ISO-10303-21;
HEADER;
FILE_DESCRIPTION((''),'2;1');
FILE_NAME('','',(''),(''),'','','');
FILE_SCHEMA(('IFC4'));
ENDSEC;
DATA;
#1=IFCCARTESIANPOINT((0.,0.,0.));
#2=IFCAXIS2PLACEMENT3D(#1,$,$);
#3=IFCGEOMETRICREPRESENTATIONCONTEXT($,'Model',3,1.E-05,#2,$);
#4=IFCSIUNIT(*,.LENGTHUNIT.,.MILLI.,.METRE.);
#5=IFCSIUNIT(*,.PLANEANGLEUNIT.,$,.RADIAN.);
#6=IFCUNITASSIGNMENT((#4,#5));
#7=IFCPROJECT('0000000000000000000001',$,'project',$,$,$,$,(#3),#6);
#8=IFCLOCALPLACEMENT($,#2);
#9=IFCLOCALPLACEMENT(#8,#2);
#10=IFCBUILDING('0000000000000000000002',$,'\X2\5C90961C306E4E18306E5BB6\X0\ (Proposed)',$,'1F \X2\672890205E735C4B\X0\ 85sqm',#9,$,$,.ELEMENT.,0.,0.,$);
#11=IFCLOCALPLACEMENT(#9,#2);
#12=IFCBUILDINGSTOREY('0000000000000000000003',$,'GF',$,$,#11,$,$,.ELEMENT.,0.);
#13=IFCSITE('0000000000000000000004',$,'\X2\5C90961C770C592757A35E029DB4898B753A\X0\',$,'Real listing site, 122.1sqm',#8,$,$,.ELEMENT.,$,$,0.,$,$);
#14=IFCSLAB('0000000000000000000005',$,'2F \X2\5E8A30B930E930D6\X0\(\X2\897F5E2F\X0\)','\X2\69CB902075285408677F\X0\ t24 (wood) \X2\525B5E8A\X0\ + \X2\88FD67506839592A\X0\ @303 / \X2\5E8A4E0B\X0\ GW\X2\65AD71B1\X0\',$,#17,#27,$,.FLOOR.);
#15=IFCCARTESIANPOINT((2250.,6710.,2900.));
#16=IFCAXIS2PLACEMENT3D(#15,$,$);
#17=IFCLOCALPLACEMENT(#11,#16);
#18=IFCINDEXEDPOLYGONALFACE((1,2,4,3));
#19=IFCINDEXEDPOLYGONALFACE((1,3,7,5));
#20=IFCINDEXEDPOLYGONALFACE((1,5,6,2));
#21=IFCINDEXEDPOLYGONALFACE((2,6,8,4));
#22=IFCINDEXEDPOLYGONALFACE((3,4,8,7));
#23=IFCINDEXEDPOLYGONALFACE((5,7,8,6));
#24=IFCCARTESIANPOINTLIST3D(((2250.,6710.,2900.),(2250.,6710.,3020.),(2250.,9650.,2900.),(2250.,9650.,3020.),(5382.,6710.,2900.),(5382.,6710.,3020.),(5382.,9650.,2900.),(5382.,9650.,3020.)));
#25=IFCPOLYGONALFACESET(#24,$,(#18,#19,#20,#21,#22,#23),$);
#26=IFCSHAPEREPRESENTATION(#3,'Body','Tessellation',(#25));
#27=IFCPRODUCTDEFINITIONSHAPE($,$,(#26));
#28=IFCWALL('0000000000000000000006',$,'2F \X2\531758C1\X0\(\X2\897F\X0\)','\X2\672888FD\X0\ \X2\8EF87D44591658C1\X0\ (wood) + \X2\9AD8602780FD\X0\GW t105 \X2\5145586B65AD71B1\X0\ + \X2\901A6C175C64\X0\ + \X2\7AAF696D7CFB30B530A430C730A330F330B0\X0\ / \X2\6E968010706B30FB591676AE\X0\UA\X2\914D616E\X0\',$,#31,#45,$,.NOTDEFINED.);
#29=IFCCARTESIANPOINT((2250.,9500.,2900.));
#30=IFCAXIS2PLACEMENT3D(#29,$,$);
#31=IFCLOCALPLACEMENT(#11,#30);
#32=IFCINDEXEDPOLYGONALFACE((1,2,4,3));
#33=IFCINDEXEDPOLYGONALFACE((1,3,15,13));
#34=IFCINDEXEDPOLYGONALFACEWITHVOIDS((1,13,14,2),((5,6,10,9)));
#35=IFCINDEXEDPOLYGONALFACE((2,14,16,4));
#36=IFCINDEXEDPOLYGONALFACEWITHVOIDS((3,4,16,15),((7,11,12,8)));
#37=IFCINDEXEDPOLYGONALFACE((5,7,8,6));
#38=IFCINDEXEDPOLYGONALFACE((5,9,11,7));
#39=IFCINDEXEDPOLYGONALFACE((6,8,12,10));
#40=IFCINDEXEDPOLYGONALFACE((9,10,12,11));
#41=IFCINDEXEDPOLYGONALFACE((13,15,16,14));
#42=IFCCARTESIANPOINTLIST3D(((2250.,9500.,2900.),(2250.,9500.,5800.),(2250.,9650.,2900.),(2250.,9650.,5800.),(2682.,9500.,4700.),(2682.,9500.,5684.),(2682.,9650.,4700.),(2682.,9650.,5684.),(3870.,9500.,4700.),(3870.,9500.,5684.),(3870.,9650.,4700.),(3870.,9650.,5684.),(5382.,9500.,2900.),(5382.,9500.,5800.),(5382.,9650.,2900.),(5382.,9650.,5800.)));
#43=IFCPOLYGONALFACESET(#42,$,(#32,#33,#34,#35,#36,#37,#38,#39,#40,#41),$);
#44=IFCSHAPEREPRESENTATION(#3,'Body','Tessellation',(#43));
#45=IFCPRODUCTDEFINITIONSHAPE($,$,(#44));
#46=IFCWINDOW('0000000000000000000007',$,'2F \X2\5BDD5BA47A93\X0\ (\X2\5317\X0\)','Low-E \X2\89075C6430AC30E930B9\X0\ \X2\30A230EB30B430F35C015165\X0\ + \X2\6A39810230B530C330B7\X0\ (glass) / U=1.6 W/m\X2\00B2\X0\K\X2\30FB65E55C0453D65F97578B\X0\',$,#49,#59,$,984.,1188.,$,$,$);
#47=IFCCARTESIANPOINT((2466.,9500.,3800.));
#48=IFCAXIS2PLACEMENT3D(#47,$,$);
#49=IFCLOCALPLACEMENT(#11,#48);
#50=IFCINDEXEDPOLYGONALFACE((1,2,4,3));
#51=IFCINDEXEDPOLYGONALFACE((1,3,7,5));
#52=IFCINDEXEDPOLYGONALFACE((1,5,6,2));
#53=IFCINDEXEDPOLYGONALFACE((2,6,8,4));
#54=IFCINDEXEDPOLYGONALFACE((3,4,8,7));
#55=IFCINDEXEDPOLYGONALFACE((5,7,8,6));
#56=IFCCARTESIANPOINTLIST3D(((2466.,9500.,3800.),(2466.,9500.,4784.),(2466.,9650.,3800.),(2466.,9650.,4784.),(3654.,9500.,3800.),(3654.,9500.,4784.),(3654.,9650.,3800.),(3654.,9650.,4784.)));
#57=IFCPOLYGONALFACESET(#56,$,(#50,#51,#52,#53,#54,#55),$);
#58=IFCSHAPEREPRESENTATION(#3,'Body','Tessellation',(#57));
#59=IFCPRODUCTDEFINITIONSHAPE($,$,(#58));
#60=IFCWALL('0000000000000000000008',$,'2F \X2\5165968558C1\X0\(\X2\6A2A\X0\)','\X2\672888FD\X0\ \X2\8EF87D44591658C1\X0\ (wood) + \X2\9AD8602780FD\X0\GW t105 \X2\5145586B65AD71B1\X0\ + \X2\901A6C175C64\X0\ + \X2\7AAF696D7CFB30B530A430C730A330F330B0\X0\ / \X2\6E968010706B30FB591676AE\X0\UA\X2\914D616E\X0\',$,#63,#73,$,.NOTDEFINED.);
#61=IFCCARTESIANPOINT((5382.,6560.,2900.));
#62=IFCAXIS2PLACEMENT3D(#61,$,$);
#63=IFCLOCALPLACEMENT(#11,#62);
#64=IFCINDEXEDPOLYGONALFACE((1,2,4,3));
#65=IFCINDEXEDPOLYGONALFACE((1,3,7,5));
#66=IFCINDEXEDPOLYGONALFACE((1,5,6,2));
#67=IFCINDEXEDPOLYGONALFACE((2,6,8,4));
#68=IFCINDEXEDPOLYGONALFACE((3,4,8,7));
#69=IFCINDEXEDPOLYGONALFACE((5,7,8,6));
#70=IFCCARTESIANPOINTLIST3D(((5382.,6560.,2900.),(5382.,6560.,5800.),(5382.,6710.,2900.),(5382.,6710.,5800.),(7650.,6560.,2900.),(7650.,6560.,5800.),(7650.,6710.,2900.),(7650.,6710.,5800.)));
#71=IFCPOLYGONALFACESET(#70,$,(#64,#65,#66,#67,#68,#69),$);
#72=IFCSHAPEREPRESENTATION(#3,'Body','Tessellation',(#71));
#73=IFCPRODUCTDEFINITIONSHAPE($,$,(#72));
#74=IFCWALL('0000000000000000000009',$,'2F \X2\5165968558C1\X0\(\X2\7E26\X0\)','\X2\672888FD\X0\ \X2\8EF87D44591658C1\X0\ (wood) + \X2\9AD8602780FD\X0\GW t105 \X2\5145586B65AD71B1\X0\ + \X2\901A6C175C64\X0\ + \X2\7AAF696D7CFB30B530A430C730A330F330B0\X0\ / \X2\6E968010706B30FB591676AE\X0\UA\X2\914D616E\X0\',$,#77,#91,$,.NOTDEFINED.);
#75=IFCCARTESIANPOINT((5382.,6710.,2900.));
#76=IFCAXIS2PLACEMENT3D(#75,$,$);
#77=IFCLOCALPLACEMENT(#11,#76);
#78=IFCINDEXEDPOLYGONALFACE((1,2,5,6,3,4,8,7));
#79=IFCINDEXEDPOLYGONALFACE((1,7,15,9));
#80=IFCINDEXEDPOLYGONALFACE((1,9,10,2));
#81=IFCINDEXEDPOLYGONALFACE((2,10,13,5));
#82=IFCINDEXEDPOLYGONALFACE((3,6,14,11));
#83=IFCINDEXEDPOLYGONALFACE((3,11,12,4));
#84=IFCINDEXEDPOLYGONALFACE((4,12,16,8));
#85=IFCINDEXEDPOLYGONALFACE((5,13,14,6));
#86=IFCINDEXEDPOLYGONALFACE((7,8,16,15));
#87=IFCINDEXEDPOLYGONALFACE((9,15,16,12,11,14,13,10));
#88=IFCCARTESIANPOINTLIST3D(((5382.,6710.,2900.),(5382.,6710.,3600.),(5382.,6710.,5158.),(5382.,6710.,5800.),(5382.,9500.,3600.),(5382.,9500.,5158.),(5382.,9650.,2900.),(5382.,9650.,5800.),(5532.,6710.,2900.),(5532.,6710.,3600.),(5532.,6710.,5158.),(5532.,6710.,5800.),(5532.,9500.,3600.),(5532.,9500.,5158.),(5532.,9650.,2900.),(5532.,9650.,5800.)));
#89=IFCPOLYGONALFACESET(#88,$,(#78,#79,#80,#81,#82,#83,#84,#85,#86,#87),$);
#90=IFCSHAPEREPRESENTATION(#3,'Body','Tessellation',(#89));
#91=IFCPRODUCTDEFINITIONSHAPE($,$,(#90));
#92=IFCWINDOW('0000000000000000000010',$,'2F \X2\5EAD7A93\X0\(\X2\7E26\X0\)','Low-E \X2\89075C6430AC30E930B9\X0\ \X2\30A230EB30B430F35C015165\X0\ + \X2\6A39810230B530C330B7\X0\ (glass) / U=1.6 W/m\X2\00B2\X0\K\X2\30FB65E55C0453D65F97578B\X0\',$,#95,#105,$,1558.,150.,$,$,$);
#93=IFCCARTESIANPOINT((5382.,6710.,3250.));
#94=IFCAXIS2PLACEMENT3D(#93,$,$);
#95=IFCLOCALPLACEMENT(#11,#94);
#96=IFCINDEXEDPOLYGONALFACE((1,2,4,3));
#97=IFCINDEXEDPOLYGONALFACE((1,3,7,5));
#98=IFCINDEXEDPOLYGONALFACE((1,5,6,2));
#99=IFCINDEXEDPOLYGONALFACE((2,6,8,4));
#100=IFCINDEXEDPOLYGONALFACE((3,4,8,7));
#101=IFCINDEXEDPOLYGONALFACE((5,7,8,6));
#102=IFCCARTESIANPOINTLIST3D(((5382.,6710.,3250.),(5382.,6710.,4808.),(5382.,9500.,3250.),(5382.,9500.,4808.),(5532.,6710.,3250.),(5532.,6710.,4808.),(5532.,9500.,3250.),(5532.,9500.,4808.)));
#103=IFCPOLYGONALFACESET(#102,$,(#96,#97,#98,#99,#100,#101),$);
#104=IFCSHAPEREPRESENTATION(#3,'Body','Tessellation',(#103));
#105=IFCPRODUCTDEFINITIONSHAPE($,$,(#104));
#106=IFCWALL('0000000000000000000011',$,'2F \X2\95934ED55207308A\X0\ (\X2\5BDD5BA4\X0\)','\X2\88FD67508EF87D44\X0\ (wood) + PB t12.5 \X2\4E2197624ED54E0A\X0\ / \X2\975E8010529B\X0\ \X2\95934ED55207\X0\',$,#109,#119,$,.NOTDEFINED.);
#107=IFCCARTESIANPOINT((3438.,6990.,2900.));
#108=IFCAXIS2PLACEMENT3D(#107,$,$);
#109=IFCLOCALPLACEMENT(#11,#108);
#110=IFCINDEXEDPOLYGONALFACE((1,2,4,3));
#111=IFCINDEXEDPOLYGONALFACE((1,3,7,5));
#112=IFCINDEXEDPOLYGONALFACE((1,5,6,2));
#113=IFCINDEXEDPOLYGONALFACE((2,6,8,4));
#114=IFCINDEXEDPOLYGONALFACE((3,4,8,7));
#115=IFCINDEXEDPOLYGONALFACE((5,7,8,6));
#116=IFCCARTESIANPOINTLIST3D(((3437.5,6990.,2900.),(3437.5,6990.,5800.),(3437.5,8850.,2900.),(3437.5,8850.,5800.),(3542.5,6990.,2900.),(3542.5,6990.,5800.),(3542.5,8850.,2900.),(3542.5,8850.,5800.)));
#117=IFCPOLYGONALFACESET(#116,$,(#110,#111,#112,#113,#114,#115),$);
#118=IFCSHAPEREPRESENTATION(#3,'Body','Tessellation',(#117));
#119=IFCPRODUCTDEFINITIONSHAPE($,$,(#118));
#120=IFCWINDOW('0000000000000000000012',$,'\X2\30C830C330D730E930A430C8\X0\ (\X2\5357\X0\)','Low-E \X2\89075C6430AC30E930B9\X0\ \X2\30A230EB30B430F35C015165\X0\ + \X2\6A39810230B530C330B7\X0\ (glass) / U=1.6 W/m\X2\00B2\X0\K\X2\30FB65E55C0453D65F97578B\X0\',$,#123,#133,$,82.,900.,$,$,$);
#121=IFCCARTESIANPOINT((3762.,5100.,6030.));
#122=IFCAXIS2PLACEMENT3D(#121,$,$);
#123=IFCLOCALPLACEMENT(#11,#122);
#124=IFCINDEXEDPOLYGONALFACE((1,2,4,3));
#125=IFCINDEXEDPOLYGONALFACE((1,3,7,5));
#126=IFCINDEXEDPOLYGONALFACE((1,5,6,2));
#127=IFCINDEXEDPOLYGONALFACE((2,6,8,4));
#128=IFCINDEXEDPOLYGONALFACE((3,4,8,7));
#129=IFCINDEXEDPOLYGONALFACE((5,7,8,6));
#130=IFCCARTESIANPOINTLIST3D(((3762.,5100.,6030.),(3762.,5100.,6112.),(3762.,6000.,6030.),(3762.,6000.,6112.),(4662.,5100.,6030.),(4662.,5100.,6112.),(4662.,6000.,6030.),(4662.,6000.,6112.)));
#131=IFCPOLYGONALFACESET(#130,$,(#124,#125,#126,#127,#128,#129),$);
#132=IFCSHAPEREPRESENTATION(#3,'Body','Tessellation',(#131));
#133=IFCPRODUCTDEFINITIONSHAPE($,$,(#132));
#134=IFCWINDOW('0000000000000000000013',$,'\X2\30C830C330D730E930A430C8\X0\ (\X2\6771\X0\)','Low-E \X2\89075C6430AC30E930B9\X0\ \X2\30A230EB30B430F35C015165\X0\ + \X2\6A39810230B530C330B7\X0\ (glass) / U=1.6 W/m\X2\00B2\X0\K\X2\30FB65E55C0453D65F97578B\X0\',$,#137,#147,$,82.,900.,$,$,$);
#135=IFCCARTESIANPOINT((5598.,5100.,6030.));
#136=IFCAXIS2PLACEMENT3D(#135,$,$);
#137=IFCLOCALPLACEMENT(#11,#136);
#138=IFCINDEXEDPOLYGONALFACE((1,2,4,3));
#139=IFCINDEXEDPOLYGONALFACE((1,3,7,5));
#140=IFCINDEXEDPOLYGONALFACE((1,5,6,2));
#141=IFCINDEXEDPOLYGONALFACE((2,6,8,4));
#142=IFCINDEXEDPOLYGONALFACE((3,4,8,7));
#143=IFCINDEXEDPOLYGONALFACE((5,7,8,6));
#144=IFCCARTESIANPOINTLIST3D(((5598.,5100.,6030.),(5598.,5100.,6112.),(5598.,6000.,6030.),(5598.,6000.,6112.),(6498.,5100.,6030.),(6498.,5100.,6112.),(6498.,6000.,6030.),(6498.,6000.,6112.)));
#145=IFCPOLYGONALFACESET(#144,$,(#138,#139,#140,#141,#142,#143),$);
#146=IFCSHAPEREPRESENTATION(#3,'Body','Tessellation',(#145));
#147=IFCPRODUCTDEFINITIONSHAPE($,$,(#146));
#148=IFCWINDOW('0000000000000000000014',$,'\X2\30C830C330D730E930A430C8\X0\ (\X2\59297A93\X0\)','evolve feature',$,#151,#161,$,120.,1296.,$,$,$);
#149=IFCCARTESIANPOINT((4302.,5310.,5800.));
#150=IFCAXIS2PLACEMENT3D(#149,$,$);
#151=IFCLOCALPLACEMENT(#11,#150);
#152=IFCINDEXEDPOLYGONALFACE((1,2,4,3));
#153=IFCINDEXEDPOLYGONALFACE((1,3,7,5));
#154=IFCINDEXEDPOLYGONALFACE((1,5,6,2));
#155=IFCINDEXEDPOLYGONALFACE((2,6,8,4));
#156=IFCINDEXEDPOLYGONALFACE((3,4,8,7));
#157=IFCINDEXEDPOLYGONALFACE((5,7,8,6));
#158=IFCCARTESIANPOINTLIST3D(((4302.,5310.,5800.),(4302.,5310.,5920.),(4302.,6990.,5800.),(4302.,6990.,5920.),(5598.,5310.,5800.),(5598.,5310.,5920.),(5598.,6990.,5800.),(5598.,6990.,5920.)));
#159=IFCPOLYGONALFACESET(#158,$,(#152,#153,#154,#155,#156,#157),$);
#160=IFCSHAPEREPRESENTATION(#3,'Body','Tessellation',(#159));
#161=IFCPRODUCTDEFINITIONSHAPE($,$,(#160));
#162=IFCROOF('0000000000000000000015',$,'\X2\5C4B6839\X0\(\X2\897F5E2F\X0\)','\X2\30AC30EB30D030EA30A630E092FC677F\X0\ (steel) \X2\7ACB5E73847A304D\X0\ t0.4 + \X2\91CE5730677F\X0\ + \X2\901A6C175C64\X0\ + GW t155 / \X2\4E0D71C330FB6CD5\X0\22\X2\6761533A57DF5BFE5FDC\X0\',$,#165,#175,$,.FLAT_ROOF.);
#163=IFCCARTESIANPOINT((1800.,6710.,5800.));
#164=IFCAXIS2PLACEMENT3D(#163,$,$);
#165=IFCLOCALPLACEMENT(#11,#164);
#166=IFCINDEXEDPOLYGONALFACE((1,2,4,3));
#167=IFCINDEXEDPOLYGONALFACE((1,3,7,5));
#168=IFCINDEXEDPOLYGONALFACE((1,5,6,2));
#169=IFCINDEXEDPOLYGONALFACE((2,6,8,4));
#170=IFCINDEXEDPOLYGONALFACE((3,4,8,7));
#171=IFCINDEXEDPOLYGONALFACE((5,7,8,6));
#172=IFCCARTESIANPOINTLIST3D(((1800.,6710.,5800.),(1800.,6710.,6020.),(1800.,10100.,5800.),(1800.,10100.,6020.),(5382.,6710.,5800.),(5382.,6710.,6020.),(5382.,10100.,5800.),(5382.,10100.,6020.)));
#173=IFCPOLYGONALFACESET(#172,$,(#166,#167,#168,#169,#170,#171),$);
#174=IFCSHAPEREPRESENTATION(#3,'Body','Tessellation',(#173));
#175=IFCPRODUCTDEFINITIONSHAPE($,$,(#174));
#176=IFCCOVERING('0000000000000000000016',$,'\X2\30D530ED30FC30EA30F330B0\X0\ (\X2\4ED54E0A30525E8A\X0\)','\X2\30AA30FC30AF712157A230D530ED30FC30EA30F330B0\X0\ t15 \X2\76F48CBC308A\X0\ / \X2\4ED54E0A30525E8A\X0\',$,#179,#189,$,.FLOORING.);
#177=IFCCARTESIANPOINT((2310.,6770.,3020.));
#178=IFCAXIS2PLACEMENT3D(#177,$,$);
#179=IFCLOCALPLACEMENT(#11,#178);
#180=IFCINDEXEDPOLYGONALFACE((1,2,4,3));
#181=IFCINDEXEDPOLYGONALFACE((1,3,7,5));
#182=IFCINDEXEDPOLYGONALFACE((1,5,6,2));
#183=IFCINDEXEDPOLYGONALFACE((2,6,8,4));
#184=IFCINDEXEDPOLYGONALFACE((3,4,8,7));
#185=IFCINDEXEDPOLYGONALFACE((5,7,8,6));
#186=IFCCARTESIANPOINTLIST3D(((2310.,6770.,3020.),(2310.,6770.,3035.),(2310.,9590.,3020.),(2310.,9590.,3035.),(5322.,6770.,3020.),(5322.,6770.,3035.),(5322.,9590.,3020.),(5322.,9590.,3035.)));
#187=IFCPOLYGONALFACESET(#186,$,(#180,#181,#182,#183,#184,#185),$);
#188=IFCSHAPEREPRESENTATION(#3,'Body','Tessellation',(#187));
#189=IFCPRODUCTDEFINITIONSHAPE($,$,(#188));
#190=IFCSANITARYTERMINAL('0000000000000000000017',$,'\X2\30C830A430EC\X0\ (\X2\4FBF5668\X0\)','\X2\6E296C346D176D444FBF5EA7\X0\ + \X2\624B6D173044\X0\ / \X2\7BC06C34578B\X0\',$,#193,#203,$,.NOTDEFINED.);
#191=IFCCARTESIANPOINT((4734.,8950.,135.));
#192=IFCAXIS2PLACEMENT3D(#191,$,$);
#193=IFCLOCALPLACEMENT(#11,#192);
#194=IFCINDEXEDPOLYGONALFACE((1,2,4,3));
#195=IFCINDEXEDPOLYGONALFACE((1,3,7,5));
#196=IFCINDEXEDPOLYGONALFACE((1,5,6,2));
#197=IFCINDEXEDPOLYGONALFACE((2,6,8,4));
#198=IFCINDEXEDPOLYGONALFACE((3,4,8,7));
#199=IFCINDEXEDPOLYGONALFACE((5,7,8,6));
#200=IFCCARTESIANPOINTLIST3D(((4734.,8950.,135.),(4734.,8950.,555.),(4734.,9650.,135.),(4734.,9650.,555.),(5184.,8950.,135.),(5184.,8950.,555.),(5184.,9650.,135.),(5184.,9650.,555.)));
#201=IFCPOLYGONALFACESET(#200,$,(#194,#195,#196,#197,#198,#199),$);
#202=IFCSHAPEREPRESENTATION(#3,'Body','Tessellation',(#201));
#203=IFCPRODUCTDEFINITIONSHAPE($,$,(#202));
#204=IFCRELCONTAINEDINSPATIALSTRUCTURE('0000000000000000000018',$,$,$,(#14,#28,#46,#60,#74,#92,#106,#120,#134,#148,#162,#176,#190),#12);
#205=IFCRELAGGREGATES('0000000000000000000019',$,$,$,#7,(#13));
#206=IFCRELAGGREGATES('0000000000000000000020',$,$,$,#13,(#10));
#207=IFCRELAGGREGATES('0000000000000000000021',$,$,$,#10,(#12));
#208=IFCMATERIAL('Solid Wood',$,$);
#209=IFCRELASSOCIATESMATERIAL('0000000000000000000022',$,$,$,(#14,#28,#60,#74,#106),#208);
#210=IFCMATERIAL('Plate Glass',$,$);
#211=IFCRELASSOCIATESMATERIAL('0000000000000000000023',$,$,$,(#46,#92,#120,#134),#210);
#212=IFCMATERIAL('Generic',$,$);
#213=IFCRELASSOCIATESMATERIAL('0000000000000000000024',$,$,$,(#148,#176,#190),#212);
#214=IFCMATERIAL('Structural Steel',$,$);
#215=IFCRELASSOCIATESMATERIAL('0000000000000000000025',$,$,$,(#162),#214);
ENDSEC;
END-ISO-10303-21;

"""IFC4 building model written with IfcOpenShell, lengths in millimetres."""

from ifc_helpers import new_model, si_unit, frame, frame_2d, origin, place, context, project, spatial, rectangle, extrude, material, element, fill, save


model = new_model("IFC4")

# Units and contexts
model_context = context("Model", 3, precision=1e-05, world=origin())
ifc_project = project(units=[si_unit("LENGTHUNIT", "METRE", prefix="MILLI"), si_unit("PLANEANGLEUNIT", "RADIAN")], contexts=[model_context])

# Site, building, storey
site_placement = place(None, origin())
site = spatial("IfcSite", under=ifc_project, at=site_placement, Name="岐阜県大垣市鶴見町", ObjectType="Real listing site, 122.1sqm", CompositionType="ELEMENT", RefElevation=0.0)
building_placement = place(site_placement, origin())
building = spatial("IfcBuilding", under=site, at=building_placement, Name="岐阜の丘の家 (Proposed)", ObjectType="1F 木造平屋 85sqm", CompositionType="ELEMENT", ElevationOfRefHeight=0.0, ElevationOfTerrain=0.0)
storey_placement = place(building_placement, origin())
storey = spatial("IfcBuildingStorey", under=building, at=storey_placement, Name="GF", CompositionType="ELEMENT", Elevation=0.0)

# Slab
ifc_material_1 = material(Name="Solid Wood")
slab_placement = place(storey_placement, frame((2250.0, 6710.0, 2900.0)))
element("IfcSlab", 1, at=slab_placement, inside=storey, material=ifc_material_1, Name="2F 床スラブ(西帯)", Description="構造用合板 t24 (wood) 剛床 + 製材根太 @303 / 床下 GW断熱", PredefinedType="FLOOR", context=model_context, shape_type="SweptSolid", body=[
    extrude(rectangle(XDim=3132.0, YDim=2940.0, at=frame_2d((1566.0, 1470.0))), frame((2250.0, 6710.0, 2900.0)), (0.0, 0.0, 1.0), 120.0),
])

# Wall, opening, window
wall_1_placement = place(storey_placement, frame((2250.0, 9500.0, 2900.0)))
wall_1 = element("IfcWall", 2, at=wall_1_placement, inside=storey, material=ifc_material_1, Name="2F 北壁(西)", Description="木製 軸組外壁 (wood) + 高性能GW t105 充填断熱 + 通気層 + 窯業系サイディング / 準耐火・外皮UA配慮", PredefinedType="NOTDEFINED", context=model_context, shape_type="SweptSolid", body=[
    extrude(rectangle(XDim=3132.0, YDim=150.0, at=frame_2d((1566.0, 75.0))), frame((2250.0, 9500.0, 2900.0)), (0.0, 0.0, 1.0), 2900.0),
])
opening_1_placement = place(storey_placement, frame((2466.0, 9500.0, 3800.0)))
opening_1 = element("IfcOpeningElement", 3, at=opening_1_placement, cuts=wall_1, PredefinedType="NOTDEFINED", context=model_context, shape_type="SweptSolid", body=[
    extrude(rectangle(XDim=1188.0, YDim=150.0, at=frame_2d((594.0, 75.0))), frame((2466.0, 9500.0, 3800.0)), (0.0, 0.0, 1.0), 984.0),
])
ifc_material_2 = material(Name="Plate Glass")
window_1_placement = place(storey_placement, frame((2466.0, 9500.0, 3800.0)))
window_1 = element("IfcWindow", 4, at=window_1_placement, inside=storey, material=ifc_material_2, Name="2F 寝室窓 (北)", Description="Low-E 複層ガラス アルゴン封入 + 樹脂サッシ (glass) / U=1.6 W/m²K・日射取得型", OverallHeight=984.0, OverallWidth=1188.0, context=model_context, shape_type="SweptSolid", body=[
    extrude(rectangle(XDim=1188.0, YDim=150.0, at=frame_2d((594.0, 75.0))), frame((2466.0, 9500.0, 3800.0)), (0.0, 0.0, 1.0), 984.0),
])
fill(opening_1, window_1)

# Wall
wall_2_placement = place(storey_placement, frame((5382.0, 6560.0, 2900.0)))
element("IfcWall", 5, at=wall_2_placement, inside=storey, material=ifc_material_1, Name="2F 入隅壁(横)", Description="木製 軸組外壁 (wood) + 高性能GW t105 充填断熱 + 通気層 + 窯業系サイディング / 準耐火・外皮UA配慮", PredefinedType="NOTDEFINED", context=model_context, shape_type="SweptSolid", body=[
    extrude(rectangle(XDim=2268.0, YDim=150.0, at=frame_2d((1134.0, 75.0))), frame((5382.0, 6560.0, 2900.0)), (0.0, 0.0, 1.0), 2900.0),
])

# Wall, opening, window
wall_3_placement = place(storey_placement, frame((5382.0, 6710.0, 2900.0)))
wall_3 = element("IfcWall", 6, at=wall_3_placement, inside=storey, material=ifc_material_1, Name="2F 入隅壁(縦)", Description="木製 軸組外壁 (wood) + 高性能GW t105 充填断熱 + 通気層 + 窯業系サイディング / 準耐火・外皮UA配慮", PredefinedType="NOTDEFINED", context=model_context, shape_type="SweptSolid", body=[
    extrude(rectangle(XDim=150.0, YDim=2940.0, at=frame_2d((75.0, 1470.0))), frame((5382.0, 6710.0, 2900.0)), (0.0, 0.0, 1.0), 2900.0),
])
opening_2_placement = place(storey_placement, frame((5382.0, 6710.0, 3250.0)))
opening_2 = element("IfcOpeningElement", 7, at=opening_2_placement, cuts=wall_3, PredefinedType="NOTDEFINED", context=model_context, shape_type="SweptSolid", body=[
    extrude(rectangle(XDim=150.0, YDim=2790.0, at=frame_2d((75.0, 1395.0))), frame((5382.0, 6710.0, 3250.0)), (0.0, 0.0, 1.0), 1558.0),
])
window_2_placement = place(storey_placement, frame((5382.0, 6710.0, 3250.0)))
window_2 = element("IfcWindow", 8, at=window_2_placement, inside=storey, material=ifc_material_2, Name="2F 庭窓(縦)", Description="Low-E 複層ガラス アルゴン封入 + 樹脂サッシ (glass) / U=1.6 W/m²K・日射取得型", OverallHeight=1558.0, OverallWidth=150.0, context=model_context, shape_type="SweptSolid", body=[
    extrude(rectangle(XDim=150.0, YDim=2790.0, at=frame_2d((75.0, 1395.0))), frame((5382.0, 6710.0, 3250.0)), (0.0, 0.0, 1.0), 1558.0),
])
fill(opening_2, window_2)

# Wall
wall_4_placement = place(storey_placement, frame((3438.0, 6990.0, 2900.0)))
element("IfcWall", 9, at=wall_4_placement, inside=storey, material=ifc_material_1, Name="2F 間仕切り (寝室)", Description="製材軸組 (wood) + PB t12.5 両面仕上 / 非耐力 間仕切", PredefinedType="NOTDEFINED", context=model_context, shape_type="SweptSolid", body=[
    extrude(rectangle(XDim=105.0, YDim=1860.0, at=frame_2d((52.0, 930.0))), frame((3438.0, 6990.0, 2900.0)), (0.0, 0.0, 1.0), 2900.0),
])

# Windows
window_3_placement = place(storey_placement, frame((3762.0, 5100.0, 6030.0)))
element("IfcWindow", 10, at=window_3_placement, inside=storey, material=ifc_material_2, Name="トップライト (南)", Description="Low-E 複層ガラス アルゴン封入 + 樹脂サッシ (glass) / U=1.6 W/m²K・日射取得型", OverallHeight=82.0, OverallWidth=900.0, context=model_context, shape_type="SweptSolid", body=[
    extrude(rectangle(XDim=900.0, YDim=900.0, at=frame_2d((450.0, 450.0))), frame((3762.0, 5100.0, 6030.0)), (0.0, 0.0, 1.0), 82.0),
])
window_4_placement = place(storey_placement, frame((5598.0, 5100.0, 6030.0)))
element("IfcWindow", 11, at=window_4_placement, inside=storey, material=ifc_material_2, Name="トップライト (東)", Description="Low-E 複層ガラス アルゴン封入 + 樹脂サッシ (glass) / U=1.6 W/m²K・日射取得型", OverallHeight=82.0, OverallWidth=900.0, context=model_context, shape_type="SweptSolid", body=[
    extrude(rectangle(XDim=900.0, YDim=900.0, at=frame_2d((450.0, 450.0))), frame((5598.0, 5100.0, 6030.0)), (0.0, 0.0, 1.0), 82.0),
])
ifc_material_3 = material(Name="Generic")
window_5_placement = place(storey_placement, frame((4302.0, 5310.0, 5800.0)))
element("IfcWindow", 12, at=window_5_placement, inside=storey, material=ifc_material_3, Name="トップライト (天窓)", Description="evolve feature", OverallHeight=120.0, OverallWidth=1296.0, context=model_context, shape_type="SweptSolid", body=[
    extrude(rectangle(XDim=1296.0, YDim=1680.0, at=frame_2d((648.0, 840.0))), frame((4302.0, 5310.0, 5800.0)), (0.0, 0.0, 1.0), 120.0),
])

# Roof
ifc_material_4 = material(Name="Structural Steel")
for number, where, name in (
    (13, (1800.0, 6710.0, 5800.0), "屋根(西帯)"),
):
    element("IfcRoof", number, at=place(storey_placement, frame(where)), inside=storey, material=ifc_material_4, Name=name, Description="ガルバリウム鋼板 (steel) 立平葺き t0.4 + 野地板 + 通気層 + GW t155 / 不燃・法22条区域対応", PredefinedType="FLAT_ROOF", context=model_context, shape_type="SweptSolid", body=[
        extrude(rectangle(XDim=3582.0, YDim=3390.0, at=frame_2d((1791.0, 1695.0))), frame((1800.0, 6710.0, 5800.0)), (0.0, 0.0, 1.0), 220.0),
    ])

# Covering
covering_placement = place(storey_placement, frame((2310.0, 6770.0, 3020.0)))
element("IfcCovering", 14, at=covering_placement, inside=storey, material=ifc_material_3, Name="フローリング (仕上げ床)", Description="オーク無垢フローリング t15 直貼り / 仕上げ床", PredefinedType="FLOORING", context=model_context, shape_type="SweptSolid", body=[
    extrude(rectangle(XDim=3012.0, YDim=2820.0, at=frame_2d((1506.0, 1410.0))), frame((2310.0, 6770.0, 3020.0)), (0.0, 0.0, 1.0), 15.0),
])

# Sanitary terminal
sanitary_terminal_placement = place(storey_placement, frame((4734.0, 8950.0, 135.0)))
element("IfcSanitaryTerminal", 15, at=sanitary_terminal_placement, inside=storey, material=ifc_material_3, Name="トイレ (便器)", Description="温水洗浄便座 + 手洗い / 節水型", PredefinedType="NOTDEFINED", context=model_context, shape_type="SweptSolid", body=[
    extrude(rectangle(XDim=450.0, YDim=700.0, at=frame_2d((225.0, 350.0))), frame((4734.0, 8950.0, 135.0)), (0.0, 0.0, 1.0), 420.0),
])

save(model, "model.ifc")
